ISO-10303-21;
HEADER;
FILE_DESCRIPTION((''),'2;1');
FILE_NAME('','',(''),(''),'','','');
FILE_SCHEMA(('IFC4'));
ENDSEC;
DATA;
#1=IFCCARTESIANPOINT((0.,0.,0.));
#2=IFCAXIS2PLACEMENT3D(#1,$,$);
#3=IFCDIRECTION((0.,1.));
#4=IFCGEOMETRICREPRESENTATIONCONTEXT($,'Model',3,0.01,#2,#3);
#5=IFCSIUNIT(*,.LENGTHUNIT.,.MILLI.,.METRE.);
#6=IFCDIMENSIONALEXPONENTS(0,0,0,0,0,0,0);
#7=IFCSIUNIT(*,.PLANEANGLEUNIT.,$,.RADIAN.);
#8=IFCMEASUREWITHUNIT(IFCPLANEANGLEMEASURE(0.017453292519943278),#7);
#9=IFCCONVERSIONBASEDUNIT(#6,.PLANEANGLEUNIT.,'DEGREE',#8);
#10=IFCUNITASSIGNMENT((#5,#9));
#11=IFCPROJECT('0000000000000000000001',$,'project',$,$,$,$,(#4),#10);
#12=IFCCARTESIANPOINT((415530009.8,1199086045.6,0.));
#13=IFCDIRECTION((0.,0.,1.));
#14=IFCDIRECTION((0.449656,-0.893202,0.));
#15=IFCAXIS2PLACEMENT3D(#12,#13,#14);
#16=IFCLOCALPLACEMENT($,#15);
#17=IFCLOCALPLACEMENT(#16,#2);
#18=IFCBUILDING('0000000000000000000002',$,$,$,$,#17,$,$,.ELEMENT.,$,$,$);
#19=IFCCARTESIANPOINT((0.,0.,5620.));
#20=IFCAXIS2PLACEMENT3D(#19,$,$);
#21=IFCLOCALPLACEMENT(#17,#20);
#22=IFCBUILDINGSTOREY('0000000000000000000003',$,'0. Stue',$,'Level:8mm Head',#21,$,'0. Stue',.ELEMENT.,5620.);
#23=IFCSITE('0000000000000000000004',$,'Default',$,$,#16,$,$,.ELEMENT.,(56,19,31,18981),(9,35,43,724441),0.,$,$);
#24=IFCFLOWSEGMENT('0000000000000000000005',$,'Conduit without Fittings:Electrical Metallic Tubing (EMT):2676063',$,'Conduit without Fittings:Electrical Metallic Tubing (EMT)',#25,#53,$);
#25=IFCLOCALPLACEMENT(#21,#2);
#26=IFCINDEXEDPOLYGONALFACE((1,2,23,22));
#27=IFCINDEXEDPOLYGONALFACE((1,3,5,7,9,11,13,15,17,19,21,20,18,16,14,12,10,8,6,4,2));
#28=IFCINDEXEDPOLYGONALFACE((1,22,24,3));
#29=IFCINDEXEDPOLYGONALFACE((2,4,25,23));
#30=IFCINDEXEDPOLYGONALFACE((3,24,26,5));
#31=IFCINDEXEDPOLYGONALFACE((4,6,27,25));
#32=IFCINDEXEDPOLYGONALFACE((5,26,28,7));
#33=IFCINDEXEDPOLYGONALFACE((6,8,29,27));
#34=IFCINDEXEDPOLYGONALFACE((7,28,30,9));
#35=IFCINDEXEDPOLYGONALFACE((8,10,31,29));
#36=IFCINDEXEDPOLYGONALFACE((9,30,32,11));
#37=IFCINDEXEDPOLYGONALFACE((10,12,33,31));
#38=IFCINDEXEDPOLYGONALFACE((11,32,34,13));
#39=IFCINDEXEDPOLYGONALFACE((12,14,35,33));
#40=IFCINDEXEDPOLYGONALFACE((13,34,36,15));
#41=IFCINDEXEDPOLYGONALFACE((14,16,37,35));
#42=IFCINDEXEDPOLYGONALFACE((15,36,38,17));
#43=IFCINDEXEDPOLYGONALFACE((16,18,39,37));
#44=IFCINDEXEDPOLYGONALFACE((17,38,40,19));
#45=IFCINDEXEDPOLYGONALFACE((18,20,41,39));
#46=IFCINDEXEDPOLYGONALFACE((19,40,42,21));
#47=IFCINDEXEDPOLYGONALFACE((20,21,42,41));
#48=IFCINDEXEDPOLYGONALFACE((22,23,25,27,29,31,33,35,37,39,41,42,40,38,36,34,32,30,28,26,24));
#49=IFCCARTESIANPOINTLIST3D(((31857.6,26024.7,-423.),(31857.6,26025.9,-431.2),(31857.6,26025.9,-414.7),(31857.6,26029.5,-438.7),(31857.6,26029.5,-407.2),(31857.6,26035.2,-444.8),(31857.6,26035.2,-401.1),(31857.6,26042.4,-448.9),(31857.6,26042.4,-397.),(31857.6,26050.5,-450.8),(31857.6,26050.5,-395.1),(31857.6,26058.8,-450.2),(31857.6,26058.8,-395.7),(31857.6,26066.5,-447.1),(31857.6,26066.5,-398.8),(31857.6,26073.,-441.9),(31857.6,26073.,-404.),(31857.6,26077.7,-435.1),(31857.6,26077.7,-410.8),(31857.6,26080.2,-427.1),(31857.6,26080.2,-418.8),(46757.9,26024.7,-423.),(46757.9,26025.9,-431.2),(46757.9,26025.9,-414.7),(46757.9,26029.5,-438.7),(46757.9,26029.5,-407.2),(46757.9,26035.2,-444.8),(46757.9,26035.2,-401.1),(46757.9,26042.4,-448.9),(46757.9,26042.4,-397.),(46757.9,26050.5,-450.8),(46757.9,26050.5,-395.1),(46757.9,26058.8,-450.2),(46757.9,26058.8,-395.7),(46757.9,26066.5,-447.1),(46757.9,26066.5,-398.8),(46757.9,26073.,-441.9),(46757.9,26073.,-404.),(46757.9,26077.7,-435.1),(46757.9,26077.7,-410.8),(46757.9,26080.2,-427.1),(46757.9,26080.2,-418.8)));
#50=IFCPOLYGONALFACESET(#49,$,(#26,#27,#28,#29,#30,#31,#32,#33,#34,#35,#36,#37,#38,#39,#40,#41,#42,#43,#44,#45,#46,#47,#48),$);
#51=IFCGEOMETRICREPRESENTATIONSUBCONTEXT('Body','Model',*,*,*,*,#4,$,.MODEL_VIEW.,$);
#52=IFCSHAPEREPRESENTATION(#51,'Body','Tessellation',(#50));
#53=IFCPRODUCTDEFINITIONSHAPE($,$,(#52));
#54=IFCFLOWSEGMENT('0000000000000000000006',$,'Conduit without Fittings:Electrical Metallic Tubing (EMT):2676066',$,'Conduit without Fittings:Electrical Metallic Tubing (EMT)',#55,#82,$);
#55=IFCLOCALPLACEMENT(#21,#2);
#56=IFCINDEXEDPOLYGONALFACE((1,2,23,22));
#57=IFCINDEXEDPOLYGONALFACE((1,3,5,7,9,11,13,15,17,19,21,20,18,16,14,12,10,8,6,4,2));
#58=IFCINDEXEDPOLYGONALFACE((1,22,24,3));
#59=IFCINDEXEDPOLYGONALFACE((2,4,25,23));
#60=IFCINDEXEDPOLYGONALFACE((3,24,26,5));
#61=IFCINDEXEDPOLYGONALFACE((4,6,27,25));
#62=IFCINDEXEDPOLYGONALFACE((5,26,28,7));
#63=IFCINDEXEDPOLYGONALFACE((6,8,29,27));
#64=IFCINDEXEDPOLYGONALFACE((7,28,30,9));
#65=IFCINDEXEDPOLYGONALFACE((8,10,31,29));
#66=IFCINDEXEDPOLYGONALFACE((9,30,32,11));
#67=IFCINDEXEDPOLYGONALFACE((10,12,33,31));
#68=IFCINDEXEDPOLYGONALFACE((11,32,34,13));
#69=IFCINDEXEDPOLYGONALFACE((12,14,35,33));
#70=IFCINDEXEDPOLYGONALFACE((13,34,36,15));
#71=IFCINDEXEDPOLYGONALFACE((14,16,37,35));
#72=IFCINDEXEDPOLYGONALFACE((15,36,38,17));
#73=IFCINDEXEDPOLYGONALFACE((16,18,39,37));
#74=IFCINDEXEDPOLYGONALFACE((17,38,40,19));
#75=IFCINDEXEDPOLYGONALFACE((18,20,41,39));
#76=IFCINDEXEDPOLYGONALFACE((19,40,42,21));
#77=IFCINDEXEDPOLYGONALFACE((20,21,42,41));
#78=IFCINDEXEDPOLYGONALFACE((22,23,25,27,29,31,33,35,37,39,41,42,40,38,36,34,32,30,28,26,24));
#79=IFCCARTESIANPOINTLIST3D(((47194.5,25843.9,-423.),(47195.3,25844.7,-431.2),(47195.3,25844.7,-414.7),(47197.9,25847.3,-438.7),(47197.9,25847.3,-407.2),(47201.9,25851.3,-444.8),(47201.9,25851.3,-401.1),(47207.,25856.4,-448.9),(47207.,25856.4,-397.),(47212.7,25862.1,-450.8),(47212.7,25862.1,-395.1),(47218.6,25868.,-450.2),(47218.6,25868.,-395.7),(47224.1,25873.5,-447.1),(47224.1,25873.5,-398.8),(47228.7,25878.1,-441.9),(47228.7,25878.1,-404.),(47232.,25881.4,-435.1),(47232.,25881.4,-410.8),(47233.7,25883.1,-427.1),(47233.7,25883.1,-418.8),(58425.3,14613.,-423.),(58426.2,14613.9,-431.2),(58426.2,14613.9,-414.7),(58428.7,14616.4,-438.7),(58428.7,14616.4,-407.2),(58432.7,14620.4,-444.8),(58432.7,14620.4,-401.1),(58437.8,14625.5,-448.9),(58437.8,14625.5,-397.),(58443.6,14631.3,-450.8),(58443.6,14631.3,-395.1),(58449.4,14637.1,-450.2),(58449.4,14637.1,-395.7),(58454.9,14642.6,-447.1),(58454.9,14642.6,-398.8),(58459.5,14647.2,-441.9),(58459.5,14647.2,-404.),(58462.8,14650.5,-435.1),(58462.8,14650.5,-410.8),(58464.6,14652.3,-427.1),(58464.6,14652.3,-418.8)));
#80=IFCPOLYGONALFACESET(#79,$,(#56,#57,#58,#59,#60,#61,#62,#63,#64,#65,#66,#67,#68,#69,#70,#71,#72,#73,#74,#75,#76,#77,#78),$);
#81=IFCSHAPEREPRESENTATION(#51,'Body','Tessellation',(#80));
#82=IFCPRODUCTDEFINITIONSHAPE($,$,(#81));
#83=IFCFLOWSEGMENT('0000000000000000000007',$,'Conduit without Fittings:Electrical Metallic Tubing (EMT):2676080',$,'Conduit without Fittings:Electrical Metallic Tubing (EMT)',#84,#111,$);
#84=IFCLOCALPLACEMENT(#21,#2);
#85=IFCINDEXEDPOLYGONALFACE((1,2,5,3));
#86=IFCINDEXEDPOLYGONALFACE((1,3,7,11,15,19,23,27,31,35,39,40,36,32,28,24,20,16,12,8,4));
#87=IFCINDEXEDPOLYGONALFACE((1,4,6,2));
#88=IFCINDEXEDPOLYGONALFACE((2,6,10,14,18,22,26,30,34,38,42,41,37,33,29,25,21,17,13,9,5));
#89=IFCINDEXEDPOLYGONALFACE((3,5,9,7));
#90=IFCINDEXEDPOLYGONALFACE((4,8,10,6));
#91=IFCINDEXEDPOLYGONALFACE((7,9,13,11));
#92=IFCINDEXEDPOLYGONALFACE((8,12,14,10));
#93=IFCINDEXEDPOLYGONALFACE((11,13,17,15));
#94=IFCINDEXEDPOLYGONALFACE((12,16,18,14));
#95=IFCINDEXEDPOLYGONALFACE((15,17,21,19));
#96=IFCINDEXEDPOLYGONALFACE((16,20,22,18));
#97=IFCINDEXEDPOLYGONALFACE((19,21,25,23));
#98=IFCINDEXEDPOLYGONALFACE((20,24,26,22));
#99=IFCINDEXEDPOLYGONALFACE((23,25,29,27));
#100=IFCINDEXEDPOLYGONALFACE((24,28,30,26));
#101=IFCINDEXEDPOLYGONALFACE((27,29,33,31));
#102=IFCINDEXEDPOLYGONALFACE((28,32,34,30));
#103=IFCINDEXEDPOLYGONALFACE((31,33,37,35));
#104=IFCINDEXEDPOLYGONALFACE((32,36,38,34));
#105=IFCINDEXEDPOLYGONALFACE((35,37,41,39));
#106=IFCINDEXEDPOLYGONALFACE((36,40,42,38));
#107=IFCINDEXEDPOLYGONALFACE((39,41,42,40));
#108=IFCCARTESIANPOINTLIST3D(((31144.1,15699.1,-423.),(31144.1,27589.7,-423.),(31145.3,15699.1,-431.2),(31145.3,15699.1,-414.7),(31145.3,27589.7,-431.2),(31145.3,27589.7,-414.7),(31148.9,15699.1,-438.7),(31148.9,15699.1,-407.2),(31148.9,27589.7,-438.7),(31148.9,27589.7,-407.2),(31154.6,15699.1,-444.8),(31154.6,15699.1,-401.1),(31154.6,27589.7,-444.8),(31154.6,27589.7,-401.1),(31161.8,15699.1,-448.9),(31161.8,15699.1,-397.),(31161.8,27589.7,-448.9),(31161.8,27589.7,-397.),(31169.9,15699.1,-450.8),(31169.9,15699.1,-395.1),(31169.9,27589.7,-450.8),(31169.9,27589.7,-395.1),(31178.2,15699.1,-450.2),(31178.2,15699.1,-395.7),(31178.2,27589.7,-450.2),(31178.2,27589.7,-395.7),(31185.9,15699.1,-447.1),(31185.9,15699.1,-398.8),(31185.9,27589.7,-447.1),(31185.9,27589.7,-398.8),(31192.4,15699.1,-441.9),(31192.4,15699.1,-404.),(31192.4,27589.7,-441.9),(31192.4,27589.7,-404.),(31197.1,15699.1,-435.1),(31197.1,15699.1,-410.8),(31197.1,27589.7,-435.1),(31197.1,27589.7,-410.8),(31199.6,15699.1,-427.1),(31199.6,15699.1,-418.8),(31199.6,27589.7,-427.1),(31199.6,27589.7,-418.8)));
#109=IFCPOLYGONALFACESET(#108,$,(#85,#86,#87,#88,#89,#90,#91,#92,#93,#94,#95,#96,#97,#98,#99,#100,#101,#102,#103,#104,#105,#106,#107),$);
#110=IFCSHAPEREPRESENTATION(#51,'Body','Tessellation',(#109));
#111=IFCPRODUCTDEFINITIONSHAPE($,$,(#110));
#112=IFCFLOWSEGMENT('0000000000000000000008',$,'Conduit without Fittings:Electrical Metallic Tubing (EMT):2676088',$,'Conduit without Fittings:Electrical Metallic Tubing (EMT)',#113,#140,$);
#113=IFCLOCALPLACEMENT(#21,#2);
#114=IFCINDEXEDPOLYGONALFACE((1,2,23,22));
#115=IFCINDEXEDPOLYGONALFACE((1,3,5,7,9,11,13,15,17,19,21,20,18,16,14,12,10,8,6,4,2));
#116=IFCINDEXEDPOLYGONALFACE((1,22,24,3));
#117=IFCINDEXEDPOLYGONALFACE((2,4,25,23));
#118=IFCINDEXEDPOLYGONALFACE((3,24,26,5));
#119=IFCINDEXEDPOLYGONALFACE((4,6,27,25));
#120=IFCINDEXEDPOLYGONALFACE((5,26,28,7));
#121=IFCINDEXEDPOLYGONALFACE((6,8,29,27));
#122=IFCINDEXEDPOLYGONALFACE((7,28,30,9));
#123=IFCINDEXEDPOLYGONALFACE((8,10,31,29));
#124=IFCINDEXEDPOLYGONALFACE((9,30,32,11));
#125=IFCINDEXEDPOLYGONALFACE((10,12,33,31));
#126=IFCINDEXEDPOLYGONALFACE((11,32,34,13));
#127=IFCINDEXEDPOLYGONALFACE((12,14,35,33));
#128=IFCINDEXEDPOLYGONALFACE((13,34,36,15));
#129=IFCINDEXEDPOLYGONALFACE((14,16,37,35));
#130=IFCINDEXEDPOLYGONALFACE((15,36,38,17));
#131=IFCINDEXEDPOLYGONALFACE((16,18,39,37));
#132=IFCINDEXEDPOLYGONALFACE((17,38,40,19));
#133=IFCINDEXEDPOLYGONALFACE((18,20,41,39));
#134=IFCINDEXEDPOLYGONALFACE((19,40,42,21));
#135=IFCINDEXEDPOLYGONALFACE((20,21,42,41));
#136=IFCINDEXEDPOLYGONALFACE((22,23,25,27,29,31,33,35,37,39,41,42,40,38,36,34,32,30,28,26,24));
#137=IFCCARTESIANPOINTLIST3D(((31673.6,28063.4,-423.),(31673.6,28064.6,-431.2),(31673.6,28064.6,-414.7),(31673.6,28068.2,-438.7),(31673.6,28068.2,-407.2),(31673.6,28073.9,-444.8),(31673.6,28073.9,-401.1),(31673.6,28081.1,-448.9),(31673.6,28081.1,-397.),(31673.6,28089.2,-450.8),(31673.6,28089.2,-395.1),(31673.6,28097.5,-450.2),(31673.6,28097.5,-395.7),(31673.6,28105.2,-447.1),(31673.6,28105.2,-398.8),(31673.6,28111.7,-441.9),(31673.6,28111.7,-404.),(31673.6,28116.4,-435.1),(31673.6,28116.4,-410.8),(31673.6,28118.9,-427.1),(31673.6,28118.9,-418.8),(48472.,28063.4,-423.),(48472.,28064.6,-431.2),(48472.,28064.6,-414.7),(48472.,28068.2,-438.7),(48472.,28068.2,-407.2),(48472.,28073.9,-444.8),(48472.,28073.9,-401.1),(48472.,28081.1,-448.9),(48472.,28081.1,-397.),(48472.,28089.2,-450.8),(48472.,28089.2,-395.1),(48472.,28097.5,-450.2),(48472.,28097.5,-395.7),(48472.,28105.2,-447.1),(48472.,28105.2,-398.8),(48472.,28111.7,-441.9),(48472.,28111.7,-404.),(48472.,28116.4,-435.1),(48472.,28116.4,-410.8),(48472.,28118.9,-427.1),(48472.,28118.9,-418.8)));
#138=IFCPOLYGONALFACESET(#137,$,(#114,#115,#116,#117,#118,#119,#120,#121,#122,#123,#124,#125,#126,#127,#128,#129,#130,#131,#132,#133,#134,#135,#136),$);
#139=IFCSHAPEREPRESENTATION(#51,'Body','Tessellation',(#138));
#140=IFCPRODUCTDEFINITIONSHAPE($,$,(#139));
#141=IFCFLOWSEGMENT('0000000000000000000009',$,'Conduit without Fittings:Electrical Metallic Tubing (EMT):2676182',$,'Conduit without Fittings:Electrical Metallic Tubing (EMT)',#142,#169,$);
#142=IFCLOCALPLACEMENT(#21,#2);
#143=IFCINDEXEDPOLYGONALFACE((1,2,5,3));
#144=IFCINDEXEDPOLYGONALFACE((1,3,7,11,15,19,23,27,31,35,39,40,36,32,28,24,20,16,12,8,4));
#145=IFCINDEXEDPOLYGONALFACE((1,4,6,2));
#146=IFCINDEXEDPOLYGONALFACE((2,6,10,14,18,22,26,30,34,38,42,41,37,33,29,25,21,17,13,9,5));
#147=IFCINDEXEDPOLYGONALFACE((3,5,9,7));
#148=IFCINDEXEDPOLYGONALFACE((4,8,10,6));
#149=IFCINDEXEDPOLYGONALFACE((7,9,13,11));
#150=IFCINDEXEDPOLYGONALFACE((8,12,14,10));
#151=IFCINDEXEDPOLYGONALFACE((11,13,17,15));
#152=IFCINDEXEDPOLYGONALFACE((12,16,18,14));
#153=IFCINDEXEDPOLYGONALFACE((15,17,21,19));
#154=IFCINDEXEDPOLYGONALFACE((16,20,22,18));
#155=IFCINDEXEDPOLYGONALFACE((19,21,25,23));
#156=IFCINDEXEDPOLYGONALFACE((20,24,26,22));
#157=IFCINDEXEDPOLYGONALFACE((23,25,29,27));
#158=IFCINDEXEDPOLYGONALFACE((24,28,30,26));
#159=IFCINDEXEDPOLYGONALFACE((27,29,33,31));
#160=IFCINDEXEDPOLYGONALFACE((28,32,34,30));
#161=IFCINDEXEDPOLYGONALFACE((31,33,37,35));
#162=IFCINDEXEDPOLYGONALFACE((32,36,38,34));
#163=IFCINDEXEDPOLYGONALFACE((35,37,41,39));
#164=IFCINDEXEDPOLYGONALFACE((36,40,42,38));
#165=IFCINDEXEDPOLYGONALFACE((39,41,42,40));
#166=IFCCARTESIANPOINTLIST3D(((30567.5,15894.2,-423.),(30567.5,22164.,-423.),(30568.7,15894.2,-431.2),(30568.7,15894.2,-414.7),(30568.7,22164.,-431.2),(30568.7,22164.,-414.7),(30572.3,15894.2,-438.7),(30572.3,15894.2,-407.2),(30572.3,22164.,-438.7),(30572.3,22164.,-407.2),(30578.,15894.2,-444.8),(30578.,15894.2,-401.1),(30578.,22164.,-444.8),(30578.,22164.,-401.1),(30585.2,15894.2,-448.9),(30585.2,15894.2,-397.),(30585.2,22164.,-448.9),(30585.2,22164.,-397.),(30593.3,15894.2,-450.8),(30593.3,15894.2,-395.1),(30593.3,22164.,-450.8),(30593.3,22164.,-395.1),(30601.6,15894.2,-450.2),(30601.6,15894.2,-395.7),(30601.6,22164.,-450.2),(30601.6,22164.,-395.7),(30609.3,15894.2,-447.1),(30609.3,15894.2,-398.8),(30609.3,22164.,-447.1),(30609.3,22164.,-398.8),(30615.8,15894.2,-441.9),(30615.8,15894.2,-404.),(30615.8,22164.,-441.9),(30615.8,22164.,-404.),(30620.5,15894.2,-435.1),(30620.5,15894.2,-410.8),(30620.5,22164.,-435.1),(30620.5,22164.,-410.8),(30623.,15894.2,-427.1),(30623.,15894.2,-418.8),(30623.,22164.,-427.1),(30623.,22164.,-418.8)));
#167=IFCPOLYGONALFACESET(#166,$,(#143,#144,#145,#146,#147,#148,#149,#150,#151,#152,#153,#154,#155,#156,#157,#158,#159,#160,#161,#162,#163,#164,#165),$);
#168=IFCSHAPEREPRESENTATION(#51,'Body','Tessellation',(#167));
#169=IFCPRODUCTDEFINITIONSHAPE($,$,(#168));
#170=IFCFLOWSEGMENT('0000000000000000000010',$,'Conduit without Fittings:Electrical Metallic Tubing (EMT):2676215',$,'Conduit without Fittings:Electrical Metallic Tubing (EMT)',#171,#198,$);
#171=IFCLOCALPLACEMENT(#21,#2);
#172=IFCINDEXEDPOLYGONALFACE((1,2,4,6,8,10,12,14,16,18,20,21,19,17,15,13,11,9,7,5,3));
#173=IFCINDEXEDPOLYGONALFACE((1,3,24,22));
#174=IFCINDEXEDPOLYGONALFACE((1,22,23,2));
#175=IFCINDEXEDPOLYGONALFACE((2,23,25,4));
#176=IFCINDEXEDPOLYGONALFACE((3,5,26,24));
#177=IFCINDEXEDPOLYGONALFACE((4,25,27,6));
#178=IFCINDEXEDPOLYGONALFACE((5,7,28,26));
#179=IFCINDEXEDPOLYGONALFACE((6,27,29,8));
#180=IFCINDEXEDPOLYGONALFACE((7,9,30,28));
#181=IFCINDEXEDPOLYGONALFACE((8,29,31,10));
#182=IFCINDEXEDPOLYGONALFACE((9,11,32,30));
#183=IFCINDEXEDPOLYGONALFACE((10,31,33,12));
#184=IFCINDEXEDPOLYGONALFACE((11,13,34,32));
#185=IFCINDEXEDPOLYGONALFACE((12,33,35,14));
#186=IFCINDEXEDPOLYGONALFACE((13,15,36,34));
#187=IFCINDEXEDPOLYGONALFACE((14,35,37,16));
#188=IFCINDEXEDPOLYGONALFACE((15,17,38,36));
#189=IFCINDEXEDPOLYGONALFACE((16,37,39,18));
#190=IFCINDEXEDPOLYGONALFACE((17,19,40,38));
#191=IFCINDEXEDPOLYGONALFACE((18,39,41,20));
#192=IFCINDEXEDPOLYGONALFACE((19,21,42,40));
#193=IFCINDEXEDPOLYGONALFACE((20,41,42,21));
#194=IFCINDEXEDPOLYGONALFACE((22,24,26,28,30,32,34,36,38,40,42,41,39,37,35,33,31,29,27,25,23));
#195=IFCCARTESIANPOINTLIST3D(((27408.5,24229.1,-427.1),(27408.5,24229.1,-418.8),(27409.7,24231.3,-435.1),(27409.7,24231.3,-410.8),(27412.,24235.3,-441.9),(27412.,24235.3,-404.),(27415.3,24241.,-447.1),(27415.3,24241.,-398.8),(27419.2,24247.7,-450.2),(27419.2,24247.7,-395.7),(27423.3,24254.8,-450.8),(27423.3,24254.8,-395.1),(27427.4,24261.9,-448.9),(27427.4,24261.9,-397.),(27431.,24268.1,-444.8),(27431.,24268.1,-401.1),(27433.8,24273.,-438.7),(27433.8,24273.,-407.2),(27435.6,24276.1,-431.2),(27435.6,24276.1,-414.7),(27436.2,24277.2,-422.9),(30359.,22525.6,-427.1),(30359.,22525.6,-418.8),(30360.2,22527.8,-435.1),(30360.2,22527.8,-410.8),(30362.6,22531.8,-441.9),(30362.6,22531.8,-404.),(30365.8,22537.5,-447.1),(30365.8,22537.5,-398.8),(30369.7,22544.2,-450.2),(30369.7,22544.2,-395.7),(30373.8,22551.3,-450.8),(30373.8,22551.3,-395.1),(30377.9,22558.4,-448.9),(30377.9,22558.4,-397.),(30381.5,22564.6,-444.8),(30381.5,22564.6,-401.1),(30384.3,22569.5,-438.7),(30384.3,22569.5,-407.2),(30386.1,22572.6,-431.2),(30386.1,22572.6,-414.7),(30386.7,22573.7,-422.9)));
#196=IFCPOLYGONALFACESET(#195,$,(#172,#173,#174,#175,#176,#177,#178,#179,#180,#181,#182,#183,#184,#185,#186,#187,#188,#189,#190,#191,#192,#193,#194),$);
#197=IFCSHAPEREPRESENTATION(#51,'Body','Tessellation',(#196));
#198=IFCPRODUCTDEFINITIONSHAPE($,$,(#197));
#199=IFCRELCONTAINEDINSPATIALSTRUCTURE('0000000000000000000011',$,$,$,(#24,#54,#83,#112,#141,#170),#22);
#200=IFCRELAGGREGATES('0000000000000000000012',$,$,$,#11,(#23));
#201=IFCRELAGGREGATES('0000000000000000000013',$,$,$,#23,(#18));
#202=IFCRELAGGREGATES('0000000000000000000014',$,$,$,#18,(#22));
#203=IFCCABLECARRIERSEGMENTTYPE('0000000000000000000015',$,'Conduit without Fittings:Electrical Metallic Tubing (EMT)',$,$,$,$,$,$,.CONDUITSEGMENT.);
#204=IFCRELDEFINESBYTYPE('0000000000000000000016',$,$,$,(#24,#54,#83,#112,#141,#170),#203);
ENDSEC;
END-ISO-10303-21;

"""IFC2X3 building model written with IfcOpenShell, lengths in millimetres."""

from ifc_helpers import new_model, entity, si_unit, converted_unit, direction, frame, frame_2d, origin, origin_2d_with_axis, place, context, subcontext, project, spatial, circle, extrude, type_object, element, save


model = new_model("IFC2X3")

# Units and contexts
model_context = context("Model", 3, precision=0.01, world=origin(), true_north=direction((0.0, 1.0)))
body_context = subcontext(model_context, "Body", "Model", "MODEL_VIEW")
ifc_project = project(units=[si_unit("LENGTHUNIT", "METRE", prefix="MILLI"), converted_unit("PLANEANGLEUNIT", "DEGREE", entity("IfcPlaneAngleMeasure", 0.017453292519943278), si_unit("PLANEANGLEUNIT", "RADIAN"), dimensions=[0, 0, 0, 0, 0, 0, 0])], contexts=[model_context])

# Site, building, storey
site_placement = place(None, frame((415530009.8, 1199086045.6, 0.0), z_axis=(0.0, 0.0, 1.0), x_axis=(0.449656, -0.893202, 0.0)))
site = spatial("IfcSite", under=ifc_project, at=site_placement, Name="Default", CompositionType="ELEMENT", RefLatitude=(56, 19, 31, 18981), RefLongitude=(9, 35, 43, 724441), RefElevation=0.0)
building_placement = place(site_placement, origin())
building = spatial("IfcBuilding", under=site, at=building_placement, CompositionType="ELEMENT")
storey_placement = place(building_placement, frame((0.0, 0.0, 5620.0)))
storey = spatial("IfcBuildingStorey", under=building, at=storey_placement, Name="0. Stue", ObjectType="Level:8mm Head", LongName="0. Stue", CompositionType="ELEMENT", Elevation=5620.0)

# Flow segments
cable_carrier_segment_type_1 = type_object("IfcCableCarrierSegmentType", Name="Conduit without Fittings:Electrical Metallic Tubing (EMT)", PredefinedType="CONDUITSEGMENT")
flow_segment_1_placement = place(storey_placement, origin())
element("IfcFlowSegment", 1, at=flow_segment_1_placement, inside=storey, type_object=cable_carrier_segment_type_1, Name="Conduit without Fittings:Electrical Metallic Tubing (EMT):2676063", ObjectType="Conduit without Fittings:Electrical Metallic Tubing (EMT)", context=body_context, shape_type="SweptSolid", body=[
    extrude(circle(Radius=27.9, at=origin_2d_with_axis()), frame((31857.6, 26052.6, -423.0), z_axis=(1.0, 0.0, 0.0), x_axis=(0.0, -1.0, 0.0)), (0.0, 0.0, 1.0), 14900.3),
])
flow_segment_2_placement = place(storey_placement, origin())
element("IfcFlowSegment", 2, at=flow_segment_2_placement, inside=storey, type_object=cable_carrier_segment_type_1, Name="Conduit without Fittings:Electrical Metallic Tubing (EMT):2676066", ObjectType="Conduit without Fittings:Electrical Metallic Tubing (EMT)", context=body_context, shape_type="SweptSolid", body=[
    extrude(circle(Radius=27.9, at=origin_2d_with_axis()), frame((47214.2, 25863.6, -423.0), z_axis=(0.707107, -0.707107, 0.0), x_axis=(-0.707107, -0.707107, 0.0)), (0.0, 0.0, 1.0), 15882.8),
])
flow_segment_3_placement = place(storey_placement, origin())
element("IfcFlowSegment", 3, at=flow_segment_3_placement, inside=storey, type_object=cable_carrier_segment_type_1, Name="Conduit without Fittings:Electrical Metallic Tubing (EMT):2676080", ObjectType="Conduit without Fittings:Electrical Metallic Tubing (EMT)", context=body_context, shape_type="SweptSolid", body=[
    extrude(circle(Radius=27.9, at=origin_2d_with_axis()), frame((31172.0, 15699.1, -423.0), z_axis=(0.0, 1.0, 0.0), x_axis=(-1.0, 0.0, 0.0)), (0.0, 0.0, 1.0), 11890.6),
])
flow_segment_4_placement = place(storey_placement, origin())
element("IfcFlowSegment", 4, at=flow_segment_4_placement, inside=storey, type_object=cable_carrier_segment_type_1, Name="Conduit without Fittings:Electrical Metallic Tubing (EMT):2676088", ObjectType="Conduit without Fittings:Electrical Metallic Tubing (EMT)", context=body_context, shape_type="SweptSolid", body=[
    extrude(circle(Radius=27.9, at=origin_2d_with_axis()), frame((31673.6, 28091.3, -423.0), z_axis=(1.0, 0.0, 0.0), x_axis=(0.0, -1.0, 0.0)), (0.0, 0.0, 1.0), 16798.4),
])
flow_segment_5_placement = place(storey_placement, origin())
element("IfcFlowSegment", 5, at=flow_segment_5_placement, inside=storey, type_object=cable_carrier_segment_type_1, Name="Conduit without Fittings:Electrical Metallic Tubing (EMT):2676182", ObjectType="Conduit without Fittings:Electrical Metallic Tubing (EMT)", context=body_context, shape_type="SweptSolid", body=[
    extrude(circle(Radius=27.9, at=frame_2d((0.0, 0.0), x_axis=(1.0, 0.0))), frame((30595.4, 15894.2, -423.0), z_axis=(0.0, 1.0, 0.0), x_axis=(-1.0, 0.0, 0.0)), (0.0, 0.0, 1.0), 6269.8),
])
flow_segment_6_placement = place(storey_placement, origin())
element("IfcFlowSegment", 6, at=flow_segment_6_placement, inside=storey, type_object=cable_carrier_segment_type_1, Name="Conduit without Fittings:Electrical Metallic Tubing (EMT):2676215", ObjectType="Conduit without Fittings:Electrical Metallic Tubing (EMT)", context=body_context, shape_type="SweptSolid", body=[
    extrude(circle(Radius=27.9, at=frame_2d((0.0, 0.0), x_axis=(1.0, 0.0))), frame((27422.3, 24253.0, -423.0), z_axis=(0.866025, -0.5, 0.0), x_axis=(0.5, 0.866025, 0.0)), (0.0, 0.0, 1.0), 3407.0),
])

save(model, "model.ifc")
